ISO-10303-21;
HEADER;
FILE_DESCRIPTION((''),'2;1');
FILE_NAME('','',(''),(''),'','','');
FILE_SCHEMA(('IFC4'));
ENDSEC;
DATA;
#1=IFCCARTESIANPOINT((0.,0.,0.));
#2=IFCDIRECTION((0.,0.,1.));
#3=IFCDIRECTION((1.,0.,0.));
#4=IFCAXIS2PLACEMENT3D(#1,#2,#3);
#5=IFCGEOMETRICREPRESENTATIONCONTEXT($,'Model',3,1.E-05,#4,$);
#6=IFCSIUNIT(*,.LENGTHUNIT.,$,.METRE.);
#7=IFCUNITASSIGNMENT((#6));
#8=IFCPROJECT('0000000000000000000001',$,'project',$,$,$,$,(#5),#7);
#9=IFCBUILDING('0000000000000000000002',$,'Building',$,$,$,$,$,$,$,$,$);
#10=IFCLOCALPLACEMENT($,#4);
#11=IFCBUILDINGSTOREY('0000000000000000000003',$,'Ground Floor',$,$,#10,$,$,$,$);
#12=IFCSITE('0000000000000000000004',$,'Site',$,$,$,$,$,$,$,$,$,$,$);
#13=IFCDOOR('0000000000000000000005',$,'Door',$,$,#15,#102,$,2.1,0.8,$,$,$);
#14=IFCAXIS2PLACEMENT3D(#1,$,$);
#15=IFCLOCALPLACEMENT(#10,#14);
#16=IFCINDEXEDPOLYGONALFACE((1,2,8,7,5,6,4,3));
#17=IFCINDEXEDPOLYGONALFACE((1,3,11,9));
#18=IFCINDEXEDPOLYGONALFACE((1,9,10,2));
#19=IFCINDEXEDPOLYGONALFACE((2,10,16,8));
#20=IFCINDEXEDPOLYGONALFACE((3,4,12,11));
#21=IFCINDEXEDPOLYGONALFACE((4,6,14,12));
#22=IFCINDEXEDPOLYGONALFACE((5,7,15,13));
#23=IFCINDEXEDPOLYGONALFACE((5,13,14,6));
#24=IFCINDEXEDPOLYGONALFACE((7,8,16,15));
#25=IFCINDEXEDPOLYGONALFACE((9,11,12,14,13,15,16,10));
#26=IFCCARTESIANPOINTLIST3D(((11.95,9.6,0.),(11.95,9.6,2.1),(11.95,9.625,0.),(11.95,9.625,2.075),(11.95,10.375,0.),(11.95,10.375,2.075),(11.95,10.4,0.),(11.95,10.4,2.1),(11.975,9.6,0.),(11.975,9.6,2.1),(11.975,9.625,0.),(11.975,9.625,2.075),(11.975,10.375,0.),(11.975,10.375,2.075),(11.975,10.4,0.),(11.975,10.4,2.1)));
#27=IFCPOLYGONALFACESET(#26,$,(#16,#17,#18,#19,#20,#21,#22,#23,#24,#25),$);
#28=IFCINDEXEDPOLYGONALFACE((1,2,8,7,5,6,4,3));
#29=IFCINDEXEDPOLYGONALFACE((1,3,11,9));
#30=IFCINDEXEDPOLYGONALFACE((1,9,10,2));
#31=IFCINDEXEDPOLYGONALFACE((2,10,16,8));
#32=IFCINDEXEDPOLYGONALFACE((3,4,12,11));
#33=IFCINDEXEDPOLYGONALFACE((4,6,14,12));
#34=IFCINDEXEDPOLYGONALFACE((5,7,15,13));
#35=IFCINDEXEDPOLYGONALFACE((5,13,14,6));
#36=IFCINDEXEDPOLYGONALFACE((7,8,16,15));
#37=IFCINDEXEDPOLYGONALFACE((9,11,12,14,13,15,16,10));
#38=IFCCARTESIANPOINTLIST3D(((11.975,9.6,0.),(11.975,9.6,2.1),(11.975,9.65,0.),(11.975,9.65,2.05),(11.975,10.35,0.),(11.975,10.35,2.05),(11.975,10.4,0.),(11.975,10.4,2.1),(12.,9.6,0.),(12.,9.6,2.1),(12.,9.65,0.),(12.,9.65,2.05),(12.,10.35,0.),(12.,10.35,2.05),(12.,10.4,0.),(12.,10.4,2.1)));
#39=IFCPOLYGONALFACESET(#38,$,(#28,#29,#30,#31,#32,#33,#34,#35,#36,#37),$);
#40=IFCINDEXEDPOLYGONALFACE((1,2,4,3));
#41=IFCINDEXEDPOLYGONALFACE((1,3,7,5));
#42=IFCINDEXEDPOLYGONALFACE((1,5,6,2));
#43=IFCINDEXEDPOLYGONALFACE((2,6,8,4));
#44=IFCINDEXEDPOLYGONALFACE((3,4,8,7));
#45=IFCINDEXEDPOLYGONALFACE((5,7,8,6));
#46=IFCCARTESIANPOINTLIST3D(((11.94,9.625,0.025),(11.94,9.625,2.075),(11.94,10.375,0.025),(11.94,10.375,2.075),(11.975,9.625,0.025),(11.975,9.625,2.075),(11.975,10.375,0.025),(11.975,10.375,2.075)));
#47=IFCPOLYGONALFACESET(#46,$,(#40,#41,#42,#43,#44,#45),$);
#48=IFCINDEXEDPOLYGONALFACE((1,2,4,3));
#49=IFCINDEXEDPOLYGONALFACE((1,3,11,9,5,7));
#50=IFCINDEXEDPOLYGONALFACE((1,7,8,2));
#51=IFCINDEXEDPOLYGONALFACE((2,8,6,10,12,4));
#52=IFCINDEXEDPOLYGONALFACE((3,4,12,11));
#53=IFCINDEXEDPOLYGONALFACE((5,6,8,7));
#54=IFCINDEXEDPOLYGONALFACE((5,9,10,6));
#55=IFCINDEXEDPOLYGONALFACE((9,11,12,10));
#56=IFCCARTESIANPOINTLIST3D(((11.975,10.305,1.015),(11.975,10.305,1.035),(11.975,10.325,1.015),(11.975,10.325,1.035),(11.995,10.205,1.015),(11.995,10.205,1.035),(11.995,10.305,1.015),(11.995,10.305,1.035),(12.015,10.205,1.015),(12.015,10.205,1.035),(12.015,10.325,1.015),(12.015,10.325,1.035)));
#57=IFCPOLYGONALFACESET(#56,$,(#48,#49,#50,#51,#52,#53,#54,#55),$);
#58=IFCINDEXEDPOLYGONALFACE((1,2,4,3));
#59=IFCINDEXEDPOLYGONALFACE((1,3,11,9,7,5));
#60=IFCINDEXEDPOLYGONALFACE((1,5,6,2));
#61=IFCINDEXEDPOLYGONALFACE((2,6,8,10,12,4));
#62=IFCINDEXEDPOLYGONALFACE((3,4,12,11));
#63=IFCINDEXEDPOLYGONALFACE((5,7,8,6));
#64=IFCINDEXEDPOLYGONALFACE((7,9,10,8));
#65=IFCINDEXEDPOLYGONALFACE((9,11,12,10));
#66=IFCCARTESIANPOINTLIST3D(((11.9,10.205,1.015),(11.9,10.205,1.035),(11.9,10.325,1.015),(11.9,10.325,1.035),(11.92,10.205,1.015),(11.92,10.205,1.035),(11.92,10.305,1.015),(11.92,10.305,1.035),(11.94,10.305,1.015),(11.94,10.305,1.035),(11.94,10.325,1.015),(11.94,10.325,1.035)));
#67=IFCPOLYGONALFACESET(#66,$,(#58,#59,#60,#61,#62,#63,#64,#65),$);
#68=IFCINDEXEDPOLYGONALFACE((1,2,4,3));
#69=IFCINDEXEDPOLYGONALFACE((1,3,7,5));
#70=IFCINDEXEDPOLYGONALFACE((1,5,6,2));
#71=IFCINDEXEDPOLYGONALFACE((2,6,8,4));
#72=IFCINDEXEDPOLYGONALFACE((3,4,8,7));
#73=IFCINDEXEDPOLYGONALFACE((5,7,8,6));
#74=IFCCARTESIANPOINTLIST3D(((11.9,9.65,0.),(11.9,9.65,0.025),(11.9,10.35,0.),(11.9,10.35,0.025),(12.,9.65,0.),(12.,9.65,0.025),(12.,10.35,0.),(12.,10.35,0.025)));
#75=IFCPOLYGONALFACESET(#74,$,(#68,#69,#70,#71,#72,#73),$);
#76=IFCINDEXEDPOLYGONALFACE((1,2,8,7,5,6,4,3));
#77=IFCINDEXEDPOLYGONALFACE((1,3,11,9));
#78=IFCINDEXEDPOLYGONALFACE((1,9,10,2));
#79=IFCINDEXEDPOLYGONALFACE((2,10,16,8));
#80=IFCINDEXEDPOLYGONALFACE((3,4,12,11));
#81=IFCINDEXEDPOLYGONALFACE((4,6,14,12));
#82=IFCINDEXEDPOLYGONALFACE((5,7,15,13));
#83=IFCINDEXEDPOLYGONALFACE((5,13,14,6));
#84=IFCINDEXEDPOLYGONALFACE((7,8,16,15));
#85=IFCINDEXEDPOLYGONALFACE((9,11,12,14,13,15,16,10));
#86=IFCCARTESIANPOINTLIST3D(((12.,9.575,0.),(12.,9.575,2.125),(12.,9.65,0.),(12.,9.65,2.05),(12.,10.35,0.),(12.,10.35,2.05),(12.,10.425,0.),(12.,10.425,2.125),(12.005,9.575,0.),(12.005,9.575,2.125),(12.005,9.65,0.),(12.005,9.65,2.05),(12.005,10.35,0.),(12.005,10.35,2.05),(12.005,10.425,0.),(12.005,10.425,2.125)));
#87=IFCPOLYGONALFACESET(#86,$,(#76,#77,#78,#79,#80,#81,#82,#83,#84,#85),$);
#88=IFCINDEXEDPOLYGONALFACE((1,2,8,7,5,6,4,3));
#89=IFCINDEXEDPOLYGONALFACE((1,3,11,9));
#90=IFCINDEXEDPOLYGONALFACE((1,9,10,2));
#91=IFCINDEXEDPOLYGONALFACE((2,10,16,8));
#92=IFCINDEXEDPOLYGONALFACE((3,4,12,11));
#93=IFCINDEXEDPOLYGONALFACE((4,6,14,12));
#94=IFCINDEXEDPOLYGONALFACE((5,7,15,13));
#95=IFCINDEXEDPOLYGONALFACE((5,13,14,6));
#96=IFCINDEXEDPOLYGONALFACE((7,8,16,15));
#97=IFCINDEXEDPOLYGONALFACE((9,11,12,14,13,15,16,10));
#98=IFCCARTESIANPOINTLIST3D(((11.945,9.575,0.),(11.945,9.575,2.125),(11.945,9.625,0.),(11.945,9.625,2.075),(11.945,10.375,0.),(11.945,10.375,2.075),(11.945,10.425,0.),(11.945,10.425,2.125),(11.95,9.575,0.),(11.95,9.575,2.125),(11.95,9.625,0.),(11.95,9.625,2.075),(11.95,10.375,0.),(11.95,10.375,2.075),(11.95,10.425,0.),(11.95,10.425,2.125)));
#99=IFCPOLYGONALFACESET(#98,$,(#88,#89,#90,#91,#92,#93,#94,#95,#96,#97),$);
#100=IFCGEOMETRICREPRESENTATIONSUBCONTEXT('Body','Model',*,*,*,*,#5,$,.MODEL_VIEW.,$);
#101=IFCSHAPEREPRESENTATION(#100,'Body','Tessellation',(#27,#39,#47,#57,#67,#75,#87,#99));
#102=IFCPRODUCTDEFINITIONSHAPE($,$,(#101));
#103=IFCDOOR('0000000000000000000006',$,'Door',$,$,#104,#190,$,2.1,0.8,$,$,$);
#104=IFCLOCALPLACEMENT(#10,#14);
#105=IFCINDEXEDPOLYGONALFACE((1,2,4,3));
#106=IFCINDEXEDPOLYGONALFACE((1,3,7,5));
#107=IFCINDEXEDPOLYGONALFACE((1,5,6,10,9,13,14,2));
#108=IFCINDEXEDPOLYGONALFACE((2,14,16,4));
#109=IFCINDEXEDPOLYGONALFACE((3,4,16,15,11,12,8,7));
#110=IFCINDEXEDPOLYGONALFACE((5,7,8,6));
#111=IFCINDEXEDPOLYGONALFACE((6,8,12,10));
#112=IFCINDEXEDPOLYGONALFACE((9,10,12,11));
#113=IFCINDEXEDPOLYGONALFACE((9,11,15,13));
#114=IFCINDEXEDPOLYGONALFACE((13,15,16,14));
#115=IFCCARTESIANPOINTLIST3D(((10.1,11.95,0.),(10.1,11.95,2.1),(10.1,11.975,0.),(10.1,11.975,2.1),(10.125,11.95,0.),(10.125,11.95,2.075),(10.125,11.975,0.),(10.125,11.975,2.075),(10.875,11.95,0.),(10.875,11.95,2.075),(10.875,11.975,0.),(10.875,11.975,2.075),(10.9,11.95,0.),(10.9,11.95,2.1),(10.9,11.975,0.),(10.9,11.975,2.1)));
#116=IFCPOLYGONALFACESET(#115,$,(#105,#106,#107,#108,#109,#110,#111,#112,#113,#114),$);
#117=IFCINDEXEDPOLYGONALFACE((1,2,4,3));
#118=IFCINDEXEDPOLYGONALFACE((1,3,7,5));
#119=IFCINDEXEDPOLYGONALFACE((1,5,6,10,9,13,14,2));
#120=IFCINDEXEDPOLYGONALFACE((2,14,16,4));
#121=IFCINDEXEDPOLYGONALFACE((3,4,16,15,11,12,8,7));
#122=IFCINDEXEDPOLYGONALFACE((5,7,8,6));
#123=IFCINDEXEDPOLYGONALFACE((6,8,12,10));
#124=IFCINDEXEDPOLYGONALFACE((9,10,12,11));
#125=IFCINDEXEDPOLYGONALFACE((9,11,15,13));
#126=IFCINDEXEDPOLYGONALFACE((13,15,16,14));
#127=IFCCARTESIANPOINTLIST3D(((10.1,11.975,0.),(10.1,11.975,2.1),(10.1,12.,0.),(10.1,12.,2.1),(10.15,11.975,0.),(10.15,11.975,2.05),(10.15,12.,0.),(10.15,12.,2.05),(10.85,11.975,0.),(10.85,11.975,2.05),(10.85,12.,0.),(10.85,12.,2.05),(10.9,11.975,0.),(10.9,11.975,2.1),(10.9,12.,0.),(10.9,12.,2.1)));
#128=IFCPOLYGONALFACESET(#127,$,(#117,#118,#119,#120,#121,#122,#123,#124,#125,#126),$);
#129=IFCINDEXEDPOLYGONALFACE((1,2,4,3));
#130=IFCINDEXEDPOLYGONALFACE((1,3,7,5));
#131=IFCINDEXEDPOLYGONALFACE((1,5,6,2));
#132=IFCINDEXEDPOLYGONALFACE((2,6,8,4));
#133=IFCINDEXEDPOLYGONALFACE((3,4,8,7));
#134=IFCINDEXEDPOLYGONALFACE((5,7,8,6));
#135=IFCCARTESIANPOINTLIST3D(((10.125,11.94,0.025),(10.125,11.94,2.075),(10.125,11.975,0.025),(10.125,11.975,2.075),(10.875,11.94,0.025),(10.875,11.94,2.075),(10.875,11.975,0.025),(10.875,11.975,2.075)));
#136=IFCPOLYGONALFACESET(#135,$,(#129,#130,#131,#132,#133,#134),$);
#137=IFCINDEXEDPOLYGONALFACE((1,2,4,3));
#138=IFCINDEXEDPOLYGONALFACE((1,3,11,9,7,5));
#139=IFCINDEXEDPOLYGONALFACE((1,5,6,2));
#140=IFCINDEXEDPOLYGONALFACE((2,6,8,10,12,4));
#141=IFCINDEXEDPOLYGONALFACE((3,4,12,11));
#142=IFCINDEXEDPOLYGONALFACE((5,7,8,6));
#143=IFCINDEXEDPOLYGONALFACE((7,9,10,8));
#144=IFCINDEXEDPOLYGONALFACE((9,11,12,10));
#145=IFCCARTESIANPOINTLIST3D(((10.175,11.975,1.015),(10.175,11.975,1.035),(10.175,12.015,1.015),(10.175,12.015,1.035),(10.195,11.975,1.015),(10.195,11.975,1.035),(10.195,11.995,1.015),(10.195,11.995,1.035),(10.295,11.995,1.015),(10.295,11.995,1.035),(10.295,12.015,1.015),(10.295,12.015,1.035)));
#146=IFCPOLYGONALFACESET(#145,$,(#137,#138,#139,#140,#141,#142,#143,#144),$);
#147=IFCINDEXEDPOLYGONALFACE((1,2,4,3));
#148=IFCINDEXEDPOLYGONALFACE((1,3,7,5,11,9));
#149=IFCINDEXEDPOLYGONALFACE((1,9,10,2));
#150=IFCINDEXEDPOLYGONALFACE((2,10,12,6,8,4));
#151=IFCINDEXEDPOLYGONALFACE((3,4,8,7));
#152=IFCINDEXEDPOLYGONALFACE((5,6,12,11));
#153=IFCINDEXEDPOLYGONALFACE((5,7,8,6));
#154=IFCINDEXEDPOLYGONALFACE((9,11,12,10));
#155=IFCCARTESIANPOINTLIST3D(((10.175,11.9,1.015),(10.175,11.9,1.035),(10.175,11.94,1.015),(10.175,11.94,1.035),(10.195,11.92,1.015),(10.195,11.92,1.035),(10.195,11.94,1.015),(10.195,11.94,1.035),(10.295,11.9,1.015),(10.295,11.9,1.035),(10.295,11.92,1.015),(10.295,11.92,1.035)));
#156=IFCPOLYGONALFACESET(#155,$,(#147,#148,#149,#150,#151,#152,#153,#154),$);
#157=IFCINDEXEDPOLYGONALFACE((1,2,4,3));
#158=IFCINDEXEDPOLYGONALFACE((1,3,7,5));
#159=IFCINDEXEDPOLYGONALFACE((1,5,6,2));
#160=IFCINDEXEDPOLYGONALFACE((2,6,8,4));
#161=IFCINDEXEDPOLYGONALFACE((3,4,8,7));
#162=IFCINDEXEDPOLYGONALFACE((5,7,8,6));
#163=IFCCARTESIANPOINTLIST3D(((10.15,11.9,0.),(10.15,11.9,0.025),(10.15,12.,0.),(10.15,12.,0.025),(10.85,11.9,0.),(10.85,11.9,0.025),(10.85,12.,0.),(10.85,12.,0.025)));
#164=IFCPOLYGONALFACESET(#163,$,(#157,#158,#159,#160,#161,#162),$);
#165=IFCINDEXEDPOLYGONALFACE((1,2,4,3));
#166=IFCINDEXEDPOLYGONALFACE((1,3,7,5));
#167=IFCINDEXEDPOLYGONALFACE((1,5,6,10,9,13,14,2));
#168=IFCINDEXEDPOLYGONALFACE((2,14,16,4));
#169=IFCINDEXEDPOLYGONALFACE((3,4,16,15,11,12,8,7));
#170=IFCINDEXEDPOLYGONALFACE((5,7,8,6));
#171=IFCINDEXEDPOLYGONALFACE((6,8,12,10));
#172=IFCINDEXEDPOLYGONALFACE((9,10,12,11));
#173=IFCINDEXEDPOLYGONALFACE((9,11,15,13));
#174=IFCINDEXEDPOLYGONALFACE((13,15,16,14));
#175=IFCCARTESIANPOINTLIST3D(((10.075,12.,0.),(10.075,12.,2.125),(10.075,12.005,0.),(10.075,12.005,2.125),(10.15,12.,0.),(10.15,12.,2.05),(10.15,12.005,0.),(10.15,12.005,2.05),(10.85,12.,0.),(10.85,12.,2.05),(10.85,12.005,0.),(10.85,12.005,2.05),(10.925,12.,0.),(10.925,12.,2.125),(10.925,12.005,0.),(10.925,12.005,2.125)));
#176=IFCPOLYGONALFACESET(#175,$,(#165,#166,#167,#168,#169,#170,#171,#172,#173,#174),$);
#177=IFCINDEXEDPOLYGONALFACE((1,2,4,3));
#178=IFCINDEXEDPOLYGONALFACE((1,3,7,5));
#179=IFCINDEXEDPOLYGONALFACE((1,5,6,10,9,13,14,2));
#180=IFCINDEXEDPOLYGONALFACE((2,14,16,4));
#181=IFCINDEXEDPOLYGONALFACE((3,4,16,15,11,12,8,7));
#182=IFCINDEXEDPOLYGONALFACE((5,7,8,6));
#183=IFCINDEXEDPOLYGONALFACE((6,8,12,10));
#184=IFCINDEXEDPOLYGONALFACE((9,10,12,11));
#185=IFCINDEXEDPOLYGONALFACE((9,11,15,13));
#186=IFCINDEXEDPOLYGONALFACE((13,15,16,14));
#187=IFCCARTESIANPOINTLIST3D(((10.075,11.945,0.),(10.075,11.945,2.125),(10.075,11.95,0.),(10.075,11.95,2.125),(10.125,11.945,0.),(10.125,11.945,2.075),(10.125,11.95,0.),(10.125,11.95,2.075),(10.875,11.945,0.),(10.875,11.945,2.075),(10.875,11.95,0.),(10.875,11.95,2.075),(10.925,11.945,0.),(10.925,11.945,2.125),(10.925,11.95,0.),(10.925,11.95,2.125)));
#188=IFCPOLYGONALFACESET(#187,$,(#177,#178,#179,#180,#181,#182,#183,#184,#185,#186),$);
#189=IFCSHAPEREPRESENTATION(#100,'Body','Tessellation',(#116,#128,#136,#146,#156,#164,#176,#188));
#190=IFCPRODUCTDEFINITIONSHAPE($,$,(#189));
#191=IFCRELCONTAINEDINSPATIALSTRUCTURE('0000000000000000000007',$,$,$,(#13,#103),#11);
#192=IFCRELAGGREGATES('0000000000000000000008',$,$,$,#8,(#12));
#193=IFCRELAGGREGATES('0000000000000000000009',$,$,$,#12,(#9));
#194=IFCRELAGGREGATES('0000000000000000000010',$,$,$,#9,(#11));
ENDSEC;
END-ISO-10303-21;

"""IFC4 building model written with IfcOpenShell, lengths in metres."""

from ifc_helpers import new_model, si_unit, frame, origin_with_axes, place, context, subcontext, project, spatial, line, indexed_curve, outline, extrude, element, save


model = new_model("IFC4")

# Units and contexts
model_context = context("Model", 3, precision=1e-05, world=origin_with_axes())
body_context = subcontext(model_context, "Body", "Model", "MODEL_VIEW")
ifc_project = project(units=[si_unit("LENGTHUNIT", "METRE")], contexts=[model_context])

# Site, building, storey
site = spatial("IfcSite", under=ifc_project, Name="Site")
building = spatial("IfcBuilding", under=site, Name="Building")
storey_placement = place(None, origin_with_axes())
storey = spatial("IfcBuildingStorey", under=building, at=storey_placement, Name="Ground Floor")

# Doors
door_1_placement = place(storey_placement, frame((12.0, 9.6, 0.0), z_axis=(0.0, 0.0, 1.0), x_axis=(0.0, 1.0, 0.0)))
element("IfcDoor", 1, at=door_1_placement, inside=storey, Name="Door", OverallHeight=2.1, OverallWidth=0.8, context=body_context, shape_type="SweptSolid", body=[
    extrude(outline(indexed_curve([(0.0, 0.0), (0.0, 2.1), (0.8, 2.1), (0.8, 0.0), (0.775, 0.0), (0.775, 2.075), (0.025, 2.075), (0.025, 0.0)], segments=[line(1, 2, 3, 4, 5, 6, 7, 8, 1)])), frame((0.0, 0.025, 0.0), z_axis=(0.0, -1.0, 0.0), x_axis=(1.0, 0.0, 0.0)), (0.0, 0.0, -1.0), 0.025),
    extrude(outline(indexed_curve([(0.0, 0.0), (0.0, 2.1), (0.8, 2.1), (0.8, 0.0), (0.75, 0.0), (0.75, 2.05), (0.05, 2.05), (0.05, 0.0)], segments=[line(1, 2, 3, 4, 5, 6, 7, 8, 1)])), frame((0.0, 0.0, 0.0), z_axis=(0.0, -1.0, 0.0), x_axis=(1.0, 0.0, 0.0)), (0.0, 0.0, -1.0), 0.025),
    extrude(outline(indexed_curve([(0.0, 0.0), (0.75, 0.0), (0.75, 0.035), (0.0, 0.035)], segments=[line(1, 2, 3, 4, 1)])), frame((0.025, 0.025, 0.025), z_axis=(0.0, 0.0, 1.0), x_axis=(1.0, 0.0, 0.0)), (0.0, 0.0, 1.0), 2.05),
    extrude(outline(indexed_curve([(0.0, 0.0), (0.0, -0.04), (-0.12, -0.04), (-0.12, -0.02), (-0.02, -0.02), (-0.02, 0.0)], segments=[line(1, 2, 3, 4, 5, 6, 1)])), frame((0.725, 0.025, 1.015), z_axis=(0.0, 0.0, 1.0), x_axis=(1.0, 0.0, 0.0)), (0.0, 0.0, 1.0), 0.02),
    extrude(outline(indexed_curve([(0.0, 0.0), (0.0, 0.04), (-0.12, 0.04), (-0.12, 0.02), (-0.02, 0.02), (-0.02, 0.0)], segments=[line(1, 2, 3, 4, 5, 6, 1)])), frame((0.725, 0.06, 1.015), z_axis=(0.0, 0.0, 1.0), x_axis=(1.0, 0.0, 0.0)), (0.0, 0.0, 1.0), 0.02),
    extrude(outline(indexed_curve([(0.0, 0.0), (0.7, 0.0), (0.7, 0.1), (0.0, 0.1)], segments=[line(1, 2, 3, 4, 1)])), frame((0.05, 0.0, 0.0), z_axis=(0.0, 0.0, 1.0), x_axis=(1.0, 0.0, 0.0)), (0.0, 0.0, 1.0), 0.025),
    extrude(outline(indexed_curve([(0.0, 0.0), (0.0, 2.125), (0.85, 2.125), (0.85, 0.0), (0.775, 0.0), (0.775, 2.05), (0.075, 2.05), (0.075, 0.0)], segments=[line(1, 2, 3, 4, 5, 6, 7, 8, 1)])), frame((-0.025, -0.005, 0.0), z_axis=(0.0, -1.0, 0.0), x_axis=(1.0, 0.0, 0.0)), (0.0, 0.0, -1.0), 0.005),
    extrude(outline(indexed_curve([(0.0, 0.0), (0.0, 2.125), (0.85, 2.125), (0.85, 0.0), (0.8, 0.0), (0.8, 2.075), (0.05, 2.075), (0.05, 0.0)], segments=[line(1, 2, 3, 4, 5, 6, 7, 8, 1)])), frame((-0.025, 0.05, 0.0), z_axis=(0.0, -1.0, 0.0), x_axis=(1.0, 0.0, 0.0)), (0.0, 0.0, -1.0), 0.005),
])
door_2_placement = place(storey_placement, frame((10.9, 12.0, 0.0), z_axis=(0.0, 0.0, 1.0), x_axis=(-1.0, 0.0, 0.0)))
element("IfcDoor", 2, at=door_2_placement, inside=storey, Name="Door", OverallHeight=2.1, OverallWidth=0.8, context=body_context, shape_type="SweptSolid", body=[
    extrude(outline(indexed_curve([(0.0, 0.0), (0.0, 2.1), (0.8, 2.1), (0.8, 0.0), (0.775, 0.0), (0.775, 2.075), (0.025, 2.075), (0.025, 0.0)], segments=[line(1, 2, 3, 4, 5, 6, 7, 8, 1)])), frame((0.0, 0.025, 0.0), z_axis=(0.0, -1.0, 0.0), x_axis=(1.0, 0.0, 0.0)), (0.0, 0.0, -1.0), 0.025),
    extrude(outline(indexed_curve([(0.0, 0.0), (0.0, 2.1), (0.8, 2.1), (0.8, 0.0), (0.75, 0.0), (0.75, 2.05), (0.05, 2.05), (0.05, 0.0)], segments=[line(1, 2, 3, 4, 5, 6, 7, 8, 1)])), frame((0.0, 0.0, 0.0), z_axis=(0.0, -1.0, 0.0), x_axis=(1.0, 0.0, 0.0)), (0.0, 0.0, -1.0), 0.025),
    extrude(outline(indexed_curve([(0.0, 0.0), (0.75, 0.0), (0.75, 0.035), (0.0, 0.035)], segments=[line(1, 2, 3, 4, 1)])), frame((0.025, 0.025, 0.025), z_axis=(0.0, 0.0, 1.0), x_axis=(1.0, 0.0, 0.0)), (0.0, 0.0, 1.0), 2.05),
    extrude(outline(indexed_curve([(0.0, 0.0), (0.0, -0.04), (-0.12, -0.04), (-0.12, -0.02), (-0.02, -0.02), (-0.02, 0.0)], segments=[line(1, 2, 3, 4, 5, 6, 1)])), frame((0.725, 0.025, 1.015), z_axis=(0.0, 0.0, 1.0), x_axis=(1.0, 0.0, 0.0)), (0.0, 0.0, 1.0), 0.02),
    extrude(outline(indexed_curve([(0.0, 0.0), (0.0, 0.04), (-0.12, 0.04), (-0.12, 0.02), (-0.02, 0.02), (-0.02, 0.0)], segments=[line(1, 2, 3, 4, 5, 6, 1)])), frame((0.725, 0.06, 1.015), z_axis=(0.0, 0.0, 1.0), x_axis=(1.0, 0.0, 0.0)), (0.0, 0.0, 1.0), 0.02),
    extrude(outline(indexed_curve([(0.0, 0.0), (0.7, 0.0), (0.7, 0.1), (0.0, 0.1)], segments=[line(1, 2, 3, 4, 1)])), frame((0.05, 0.0, 0.0), z_axis=(0.0, 0.0, 1.0), x_axis=(1.0, 0.0, 0.0)), (0.0, 0.0, 1.0), 0.025),
    extrude(outline(indexed_curve([(0.0, 0.0), (0.0, 2.125), (0.85, 2.125), (0.85, 0.0), (0.775, 0.0), (0.775, 2.05), (0.075, 2.05), (0.075, 0.0)], segments=[line(1, 2, 3, 4, 5, 6, 7, 8, 1)])), frame((-0.025, -0.005, 0.0), z_axis=(0.0, -1.0, 0.0), x_axis=(1.0, 0.0, 0.0)), (0.0, 0.0, -1.0), 0.005),
    extrude(outline(indexed_curve([(0.0, 0.0), (0.0, 2.125), (0.85, 2.125), (0.85, 0.0), (0.8, 0.0), (0.8, 2.075), (0.05, 2.075), (0.05, 0.0)], segments=[line(1, 2, 3, 4, 5, 6, 7, 8, 1)])), frame((-0.025, 0.05, 0.0), z_axis=(0.0, -1.0, 0.0), x_axis=(1.0, 0.0, 0.0)), (0.0, 0.0, -1.0), 0.005),
])

save(model, "model.ifc")
